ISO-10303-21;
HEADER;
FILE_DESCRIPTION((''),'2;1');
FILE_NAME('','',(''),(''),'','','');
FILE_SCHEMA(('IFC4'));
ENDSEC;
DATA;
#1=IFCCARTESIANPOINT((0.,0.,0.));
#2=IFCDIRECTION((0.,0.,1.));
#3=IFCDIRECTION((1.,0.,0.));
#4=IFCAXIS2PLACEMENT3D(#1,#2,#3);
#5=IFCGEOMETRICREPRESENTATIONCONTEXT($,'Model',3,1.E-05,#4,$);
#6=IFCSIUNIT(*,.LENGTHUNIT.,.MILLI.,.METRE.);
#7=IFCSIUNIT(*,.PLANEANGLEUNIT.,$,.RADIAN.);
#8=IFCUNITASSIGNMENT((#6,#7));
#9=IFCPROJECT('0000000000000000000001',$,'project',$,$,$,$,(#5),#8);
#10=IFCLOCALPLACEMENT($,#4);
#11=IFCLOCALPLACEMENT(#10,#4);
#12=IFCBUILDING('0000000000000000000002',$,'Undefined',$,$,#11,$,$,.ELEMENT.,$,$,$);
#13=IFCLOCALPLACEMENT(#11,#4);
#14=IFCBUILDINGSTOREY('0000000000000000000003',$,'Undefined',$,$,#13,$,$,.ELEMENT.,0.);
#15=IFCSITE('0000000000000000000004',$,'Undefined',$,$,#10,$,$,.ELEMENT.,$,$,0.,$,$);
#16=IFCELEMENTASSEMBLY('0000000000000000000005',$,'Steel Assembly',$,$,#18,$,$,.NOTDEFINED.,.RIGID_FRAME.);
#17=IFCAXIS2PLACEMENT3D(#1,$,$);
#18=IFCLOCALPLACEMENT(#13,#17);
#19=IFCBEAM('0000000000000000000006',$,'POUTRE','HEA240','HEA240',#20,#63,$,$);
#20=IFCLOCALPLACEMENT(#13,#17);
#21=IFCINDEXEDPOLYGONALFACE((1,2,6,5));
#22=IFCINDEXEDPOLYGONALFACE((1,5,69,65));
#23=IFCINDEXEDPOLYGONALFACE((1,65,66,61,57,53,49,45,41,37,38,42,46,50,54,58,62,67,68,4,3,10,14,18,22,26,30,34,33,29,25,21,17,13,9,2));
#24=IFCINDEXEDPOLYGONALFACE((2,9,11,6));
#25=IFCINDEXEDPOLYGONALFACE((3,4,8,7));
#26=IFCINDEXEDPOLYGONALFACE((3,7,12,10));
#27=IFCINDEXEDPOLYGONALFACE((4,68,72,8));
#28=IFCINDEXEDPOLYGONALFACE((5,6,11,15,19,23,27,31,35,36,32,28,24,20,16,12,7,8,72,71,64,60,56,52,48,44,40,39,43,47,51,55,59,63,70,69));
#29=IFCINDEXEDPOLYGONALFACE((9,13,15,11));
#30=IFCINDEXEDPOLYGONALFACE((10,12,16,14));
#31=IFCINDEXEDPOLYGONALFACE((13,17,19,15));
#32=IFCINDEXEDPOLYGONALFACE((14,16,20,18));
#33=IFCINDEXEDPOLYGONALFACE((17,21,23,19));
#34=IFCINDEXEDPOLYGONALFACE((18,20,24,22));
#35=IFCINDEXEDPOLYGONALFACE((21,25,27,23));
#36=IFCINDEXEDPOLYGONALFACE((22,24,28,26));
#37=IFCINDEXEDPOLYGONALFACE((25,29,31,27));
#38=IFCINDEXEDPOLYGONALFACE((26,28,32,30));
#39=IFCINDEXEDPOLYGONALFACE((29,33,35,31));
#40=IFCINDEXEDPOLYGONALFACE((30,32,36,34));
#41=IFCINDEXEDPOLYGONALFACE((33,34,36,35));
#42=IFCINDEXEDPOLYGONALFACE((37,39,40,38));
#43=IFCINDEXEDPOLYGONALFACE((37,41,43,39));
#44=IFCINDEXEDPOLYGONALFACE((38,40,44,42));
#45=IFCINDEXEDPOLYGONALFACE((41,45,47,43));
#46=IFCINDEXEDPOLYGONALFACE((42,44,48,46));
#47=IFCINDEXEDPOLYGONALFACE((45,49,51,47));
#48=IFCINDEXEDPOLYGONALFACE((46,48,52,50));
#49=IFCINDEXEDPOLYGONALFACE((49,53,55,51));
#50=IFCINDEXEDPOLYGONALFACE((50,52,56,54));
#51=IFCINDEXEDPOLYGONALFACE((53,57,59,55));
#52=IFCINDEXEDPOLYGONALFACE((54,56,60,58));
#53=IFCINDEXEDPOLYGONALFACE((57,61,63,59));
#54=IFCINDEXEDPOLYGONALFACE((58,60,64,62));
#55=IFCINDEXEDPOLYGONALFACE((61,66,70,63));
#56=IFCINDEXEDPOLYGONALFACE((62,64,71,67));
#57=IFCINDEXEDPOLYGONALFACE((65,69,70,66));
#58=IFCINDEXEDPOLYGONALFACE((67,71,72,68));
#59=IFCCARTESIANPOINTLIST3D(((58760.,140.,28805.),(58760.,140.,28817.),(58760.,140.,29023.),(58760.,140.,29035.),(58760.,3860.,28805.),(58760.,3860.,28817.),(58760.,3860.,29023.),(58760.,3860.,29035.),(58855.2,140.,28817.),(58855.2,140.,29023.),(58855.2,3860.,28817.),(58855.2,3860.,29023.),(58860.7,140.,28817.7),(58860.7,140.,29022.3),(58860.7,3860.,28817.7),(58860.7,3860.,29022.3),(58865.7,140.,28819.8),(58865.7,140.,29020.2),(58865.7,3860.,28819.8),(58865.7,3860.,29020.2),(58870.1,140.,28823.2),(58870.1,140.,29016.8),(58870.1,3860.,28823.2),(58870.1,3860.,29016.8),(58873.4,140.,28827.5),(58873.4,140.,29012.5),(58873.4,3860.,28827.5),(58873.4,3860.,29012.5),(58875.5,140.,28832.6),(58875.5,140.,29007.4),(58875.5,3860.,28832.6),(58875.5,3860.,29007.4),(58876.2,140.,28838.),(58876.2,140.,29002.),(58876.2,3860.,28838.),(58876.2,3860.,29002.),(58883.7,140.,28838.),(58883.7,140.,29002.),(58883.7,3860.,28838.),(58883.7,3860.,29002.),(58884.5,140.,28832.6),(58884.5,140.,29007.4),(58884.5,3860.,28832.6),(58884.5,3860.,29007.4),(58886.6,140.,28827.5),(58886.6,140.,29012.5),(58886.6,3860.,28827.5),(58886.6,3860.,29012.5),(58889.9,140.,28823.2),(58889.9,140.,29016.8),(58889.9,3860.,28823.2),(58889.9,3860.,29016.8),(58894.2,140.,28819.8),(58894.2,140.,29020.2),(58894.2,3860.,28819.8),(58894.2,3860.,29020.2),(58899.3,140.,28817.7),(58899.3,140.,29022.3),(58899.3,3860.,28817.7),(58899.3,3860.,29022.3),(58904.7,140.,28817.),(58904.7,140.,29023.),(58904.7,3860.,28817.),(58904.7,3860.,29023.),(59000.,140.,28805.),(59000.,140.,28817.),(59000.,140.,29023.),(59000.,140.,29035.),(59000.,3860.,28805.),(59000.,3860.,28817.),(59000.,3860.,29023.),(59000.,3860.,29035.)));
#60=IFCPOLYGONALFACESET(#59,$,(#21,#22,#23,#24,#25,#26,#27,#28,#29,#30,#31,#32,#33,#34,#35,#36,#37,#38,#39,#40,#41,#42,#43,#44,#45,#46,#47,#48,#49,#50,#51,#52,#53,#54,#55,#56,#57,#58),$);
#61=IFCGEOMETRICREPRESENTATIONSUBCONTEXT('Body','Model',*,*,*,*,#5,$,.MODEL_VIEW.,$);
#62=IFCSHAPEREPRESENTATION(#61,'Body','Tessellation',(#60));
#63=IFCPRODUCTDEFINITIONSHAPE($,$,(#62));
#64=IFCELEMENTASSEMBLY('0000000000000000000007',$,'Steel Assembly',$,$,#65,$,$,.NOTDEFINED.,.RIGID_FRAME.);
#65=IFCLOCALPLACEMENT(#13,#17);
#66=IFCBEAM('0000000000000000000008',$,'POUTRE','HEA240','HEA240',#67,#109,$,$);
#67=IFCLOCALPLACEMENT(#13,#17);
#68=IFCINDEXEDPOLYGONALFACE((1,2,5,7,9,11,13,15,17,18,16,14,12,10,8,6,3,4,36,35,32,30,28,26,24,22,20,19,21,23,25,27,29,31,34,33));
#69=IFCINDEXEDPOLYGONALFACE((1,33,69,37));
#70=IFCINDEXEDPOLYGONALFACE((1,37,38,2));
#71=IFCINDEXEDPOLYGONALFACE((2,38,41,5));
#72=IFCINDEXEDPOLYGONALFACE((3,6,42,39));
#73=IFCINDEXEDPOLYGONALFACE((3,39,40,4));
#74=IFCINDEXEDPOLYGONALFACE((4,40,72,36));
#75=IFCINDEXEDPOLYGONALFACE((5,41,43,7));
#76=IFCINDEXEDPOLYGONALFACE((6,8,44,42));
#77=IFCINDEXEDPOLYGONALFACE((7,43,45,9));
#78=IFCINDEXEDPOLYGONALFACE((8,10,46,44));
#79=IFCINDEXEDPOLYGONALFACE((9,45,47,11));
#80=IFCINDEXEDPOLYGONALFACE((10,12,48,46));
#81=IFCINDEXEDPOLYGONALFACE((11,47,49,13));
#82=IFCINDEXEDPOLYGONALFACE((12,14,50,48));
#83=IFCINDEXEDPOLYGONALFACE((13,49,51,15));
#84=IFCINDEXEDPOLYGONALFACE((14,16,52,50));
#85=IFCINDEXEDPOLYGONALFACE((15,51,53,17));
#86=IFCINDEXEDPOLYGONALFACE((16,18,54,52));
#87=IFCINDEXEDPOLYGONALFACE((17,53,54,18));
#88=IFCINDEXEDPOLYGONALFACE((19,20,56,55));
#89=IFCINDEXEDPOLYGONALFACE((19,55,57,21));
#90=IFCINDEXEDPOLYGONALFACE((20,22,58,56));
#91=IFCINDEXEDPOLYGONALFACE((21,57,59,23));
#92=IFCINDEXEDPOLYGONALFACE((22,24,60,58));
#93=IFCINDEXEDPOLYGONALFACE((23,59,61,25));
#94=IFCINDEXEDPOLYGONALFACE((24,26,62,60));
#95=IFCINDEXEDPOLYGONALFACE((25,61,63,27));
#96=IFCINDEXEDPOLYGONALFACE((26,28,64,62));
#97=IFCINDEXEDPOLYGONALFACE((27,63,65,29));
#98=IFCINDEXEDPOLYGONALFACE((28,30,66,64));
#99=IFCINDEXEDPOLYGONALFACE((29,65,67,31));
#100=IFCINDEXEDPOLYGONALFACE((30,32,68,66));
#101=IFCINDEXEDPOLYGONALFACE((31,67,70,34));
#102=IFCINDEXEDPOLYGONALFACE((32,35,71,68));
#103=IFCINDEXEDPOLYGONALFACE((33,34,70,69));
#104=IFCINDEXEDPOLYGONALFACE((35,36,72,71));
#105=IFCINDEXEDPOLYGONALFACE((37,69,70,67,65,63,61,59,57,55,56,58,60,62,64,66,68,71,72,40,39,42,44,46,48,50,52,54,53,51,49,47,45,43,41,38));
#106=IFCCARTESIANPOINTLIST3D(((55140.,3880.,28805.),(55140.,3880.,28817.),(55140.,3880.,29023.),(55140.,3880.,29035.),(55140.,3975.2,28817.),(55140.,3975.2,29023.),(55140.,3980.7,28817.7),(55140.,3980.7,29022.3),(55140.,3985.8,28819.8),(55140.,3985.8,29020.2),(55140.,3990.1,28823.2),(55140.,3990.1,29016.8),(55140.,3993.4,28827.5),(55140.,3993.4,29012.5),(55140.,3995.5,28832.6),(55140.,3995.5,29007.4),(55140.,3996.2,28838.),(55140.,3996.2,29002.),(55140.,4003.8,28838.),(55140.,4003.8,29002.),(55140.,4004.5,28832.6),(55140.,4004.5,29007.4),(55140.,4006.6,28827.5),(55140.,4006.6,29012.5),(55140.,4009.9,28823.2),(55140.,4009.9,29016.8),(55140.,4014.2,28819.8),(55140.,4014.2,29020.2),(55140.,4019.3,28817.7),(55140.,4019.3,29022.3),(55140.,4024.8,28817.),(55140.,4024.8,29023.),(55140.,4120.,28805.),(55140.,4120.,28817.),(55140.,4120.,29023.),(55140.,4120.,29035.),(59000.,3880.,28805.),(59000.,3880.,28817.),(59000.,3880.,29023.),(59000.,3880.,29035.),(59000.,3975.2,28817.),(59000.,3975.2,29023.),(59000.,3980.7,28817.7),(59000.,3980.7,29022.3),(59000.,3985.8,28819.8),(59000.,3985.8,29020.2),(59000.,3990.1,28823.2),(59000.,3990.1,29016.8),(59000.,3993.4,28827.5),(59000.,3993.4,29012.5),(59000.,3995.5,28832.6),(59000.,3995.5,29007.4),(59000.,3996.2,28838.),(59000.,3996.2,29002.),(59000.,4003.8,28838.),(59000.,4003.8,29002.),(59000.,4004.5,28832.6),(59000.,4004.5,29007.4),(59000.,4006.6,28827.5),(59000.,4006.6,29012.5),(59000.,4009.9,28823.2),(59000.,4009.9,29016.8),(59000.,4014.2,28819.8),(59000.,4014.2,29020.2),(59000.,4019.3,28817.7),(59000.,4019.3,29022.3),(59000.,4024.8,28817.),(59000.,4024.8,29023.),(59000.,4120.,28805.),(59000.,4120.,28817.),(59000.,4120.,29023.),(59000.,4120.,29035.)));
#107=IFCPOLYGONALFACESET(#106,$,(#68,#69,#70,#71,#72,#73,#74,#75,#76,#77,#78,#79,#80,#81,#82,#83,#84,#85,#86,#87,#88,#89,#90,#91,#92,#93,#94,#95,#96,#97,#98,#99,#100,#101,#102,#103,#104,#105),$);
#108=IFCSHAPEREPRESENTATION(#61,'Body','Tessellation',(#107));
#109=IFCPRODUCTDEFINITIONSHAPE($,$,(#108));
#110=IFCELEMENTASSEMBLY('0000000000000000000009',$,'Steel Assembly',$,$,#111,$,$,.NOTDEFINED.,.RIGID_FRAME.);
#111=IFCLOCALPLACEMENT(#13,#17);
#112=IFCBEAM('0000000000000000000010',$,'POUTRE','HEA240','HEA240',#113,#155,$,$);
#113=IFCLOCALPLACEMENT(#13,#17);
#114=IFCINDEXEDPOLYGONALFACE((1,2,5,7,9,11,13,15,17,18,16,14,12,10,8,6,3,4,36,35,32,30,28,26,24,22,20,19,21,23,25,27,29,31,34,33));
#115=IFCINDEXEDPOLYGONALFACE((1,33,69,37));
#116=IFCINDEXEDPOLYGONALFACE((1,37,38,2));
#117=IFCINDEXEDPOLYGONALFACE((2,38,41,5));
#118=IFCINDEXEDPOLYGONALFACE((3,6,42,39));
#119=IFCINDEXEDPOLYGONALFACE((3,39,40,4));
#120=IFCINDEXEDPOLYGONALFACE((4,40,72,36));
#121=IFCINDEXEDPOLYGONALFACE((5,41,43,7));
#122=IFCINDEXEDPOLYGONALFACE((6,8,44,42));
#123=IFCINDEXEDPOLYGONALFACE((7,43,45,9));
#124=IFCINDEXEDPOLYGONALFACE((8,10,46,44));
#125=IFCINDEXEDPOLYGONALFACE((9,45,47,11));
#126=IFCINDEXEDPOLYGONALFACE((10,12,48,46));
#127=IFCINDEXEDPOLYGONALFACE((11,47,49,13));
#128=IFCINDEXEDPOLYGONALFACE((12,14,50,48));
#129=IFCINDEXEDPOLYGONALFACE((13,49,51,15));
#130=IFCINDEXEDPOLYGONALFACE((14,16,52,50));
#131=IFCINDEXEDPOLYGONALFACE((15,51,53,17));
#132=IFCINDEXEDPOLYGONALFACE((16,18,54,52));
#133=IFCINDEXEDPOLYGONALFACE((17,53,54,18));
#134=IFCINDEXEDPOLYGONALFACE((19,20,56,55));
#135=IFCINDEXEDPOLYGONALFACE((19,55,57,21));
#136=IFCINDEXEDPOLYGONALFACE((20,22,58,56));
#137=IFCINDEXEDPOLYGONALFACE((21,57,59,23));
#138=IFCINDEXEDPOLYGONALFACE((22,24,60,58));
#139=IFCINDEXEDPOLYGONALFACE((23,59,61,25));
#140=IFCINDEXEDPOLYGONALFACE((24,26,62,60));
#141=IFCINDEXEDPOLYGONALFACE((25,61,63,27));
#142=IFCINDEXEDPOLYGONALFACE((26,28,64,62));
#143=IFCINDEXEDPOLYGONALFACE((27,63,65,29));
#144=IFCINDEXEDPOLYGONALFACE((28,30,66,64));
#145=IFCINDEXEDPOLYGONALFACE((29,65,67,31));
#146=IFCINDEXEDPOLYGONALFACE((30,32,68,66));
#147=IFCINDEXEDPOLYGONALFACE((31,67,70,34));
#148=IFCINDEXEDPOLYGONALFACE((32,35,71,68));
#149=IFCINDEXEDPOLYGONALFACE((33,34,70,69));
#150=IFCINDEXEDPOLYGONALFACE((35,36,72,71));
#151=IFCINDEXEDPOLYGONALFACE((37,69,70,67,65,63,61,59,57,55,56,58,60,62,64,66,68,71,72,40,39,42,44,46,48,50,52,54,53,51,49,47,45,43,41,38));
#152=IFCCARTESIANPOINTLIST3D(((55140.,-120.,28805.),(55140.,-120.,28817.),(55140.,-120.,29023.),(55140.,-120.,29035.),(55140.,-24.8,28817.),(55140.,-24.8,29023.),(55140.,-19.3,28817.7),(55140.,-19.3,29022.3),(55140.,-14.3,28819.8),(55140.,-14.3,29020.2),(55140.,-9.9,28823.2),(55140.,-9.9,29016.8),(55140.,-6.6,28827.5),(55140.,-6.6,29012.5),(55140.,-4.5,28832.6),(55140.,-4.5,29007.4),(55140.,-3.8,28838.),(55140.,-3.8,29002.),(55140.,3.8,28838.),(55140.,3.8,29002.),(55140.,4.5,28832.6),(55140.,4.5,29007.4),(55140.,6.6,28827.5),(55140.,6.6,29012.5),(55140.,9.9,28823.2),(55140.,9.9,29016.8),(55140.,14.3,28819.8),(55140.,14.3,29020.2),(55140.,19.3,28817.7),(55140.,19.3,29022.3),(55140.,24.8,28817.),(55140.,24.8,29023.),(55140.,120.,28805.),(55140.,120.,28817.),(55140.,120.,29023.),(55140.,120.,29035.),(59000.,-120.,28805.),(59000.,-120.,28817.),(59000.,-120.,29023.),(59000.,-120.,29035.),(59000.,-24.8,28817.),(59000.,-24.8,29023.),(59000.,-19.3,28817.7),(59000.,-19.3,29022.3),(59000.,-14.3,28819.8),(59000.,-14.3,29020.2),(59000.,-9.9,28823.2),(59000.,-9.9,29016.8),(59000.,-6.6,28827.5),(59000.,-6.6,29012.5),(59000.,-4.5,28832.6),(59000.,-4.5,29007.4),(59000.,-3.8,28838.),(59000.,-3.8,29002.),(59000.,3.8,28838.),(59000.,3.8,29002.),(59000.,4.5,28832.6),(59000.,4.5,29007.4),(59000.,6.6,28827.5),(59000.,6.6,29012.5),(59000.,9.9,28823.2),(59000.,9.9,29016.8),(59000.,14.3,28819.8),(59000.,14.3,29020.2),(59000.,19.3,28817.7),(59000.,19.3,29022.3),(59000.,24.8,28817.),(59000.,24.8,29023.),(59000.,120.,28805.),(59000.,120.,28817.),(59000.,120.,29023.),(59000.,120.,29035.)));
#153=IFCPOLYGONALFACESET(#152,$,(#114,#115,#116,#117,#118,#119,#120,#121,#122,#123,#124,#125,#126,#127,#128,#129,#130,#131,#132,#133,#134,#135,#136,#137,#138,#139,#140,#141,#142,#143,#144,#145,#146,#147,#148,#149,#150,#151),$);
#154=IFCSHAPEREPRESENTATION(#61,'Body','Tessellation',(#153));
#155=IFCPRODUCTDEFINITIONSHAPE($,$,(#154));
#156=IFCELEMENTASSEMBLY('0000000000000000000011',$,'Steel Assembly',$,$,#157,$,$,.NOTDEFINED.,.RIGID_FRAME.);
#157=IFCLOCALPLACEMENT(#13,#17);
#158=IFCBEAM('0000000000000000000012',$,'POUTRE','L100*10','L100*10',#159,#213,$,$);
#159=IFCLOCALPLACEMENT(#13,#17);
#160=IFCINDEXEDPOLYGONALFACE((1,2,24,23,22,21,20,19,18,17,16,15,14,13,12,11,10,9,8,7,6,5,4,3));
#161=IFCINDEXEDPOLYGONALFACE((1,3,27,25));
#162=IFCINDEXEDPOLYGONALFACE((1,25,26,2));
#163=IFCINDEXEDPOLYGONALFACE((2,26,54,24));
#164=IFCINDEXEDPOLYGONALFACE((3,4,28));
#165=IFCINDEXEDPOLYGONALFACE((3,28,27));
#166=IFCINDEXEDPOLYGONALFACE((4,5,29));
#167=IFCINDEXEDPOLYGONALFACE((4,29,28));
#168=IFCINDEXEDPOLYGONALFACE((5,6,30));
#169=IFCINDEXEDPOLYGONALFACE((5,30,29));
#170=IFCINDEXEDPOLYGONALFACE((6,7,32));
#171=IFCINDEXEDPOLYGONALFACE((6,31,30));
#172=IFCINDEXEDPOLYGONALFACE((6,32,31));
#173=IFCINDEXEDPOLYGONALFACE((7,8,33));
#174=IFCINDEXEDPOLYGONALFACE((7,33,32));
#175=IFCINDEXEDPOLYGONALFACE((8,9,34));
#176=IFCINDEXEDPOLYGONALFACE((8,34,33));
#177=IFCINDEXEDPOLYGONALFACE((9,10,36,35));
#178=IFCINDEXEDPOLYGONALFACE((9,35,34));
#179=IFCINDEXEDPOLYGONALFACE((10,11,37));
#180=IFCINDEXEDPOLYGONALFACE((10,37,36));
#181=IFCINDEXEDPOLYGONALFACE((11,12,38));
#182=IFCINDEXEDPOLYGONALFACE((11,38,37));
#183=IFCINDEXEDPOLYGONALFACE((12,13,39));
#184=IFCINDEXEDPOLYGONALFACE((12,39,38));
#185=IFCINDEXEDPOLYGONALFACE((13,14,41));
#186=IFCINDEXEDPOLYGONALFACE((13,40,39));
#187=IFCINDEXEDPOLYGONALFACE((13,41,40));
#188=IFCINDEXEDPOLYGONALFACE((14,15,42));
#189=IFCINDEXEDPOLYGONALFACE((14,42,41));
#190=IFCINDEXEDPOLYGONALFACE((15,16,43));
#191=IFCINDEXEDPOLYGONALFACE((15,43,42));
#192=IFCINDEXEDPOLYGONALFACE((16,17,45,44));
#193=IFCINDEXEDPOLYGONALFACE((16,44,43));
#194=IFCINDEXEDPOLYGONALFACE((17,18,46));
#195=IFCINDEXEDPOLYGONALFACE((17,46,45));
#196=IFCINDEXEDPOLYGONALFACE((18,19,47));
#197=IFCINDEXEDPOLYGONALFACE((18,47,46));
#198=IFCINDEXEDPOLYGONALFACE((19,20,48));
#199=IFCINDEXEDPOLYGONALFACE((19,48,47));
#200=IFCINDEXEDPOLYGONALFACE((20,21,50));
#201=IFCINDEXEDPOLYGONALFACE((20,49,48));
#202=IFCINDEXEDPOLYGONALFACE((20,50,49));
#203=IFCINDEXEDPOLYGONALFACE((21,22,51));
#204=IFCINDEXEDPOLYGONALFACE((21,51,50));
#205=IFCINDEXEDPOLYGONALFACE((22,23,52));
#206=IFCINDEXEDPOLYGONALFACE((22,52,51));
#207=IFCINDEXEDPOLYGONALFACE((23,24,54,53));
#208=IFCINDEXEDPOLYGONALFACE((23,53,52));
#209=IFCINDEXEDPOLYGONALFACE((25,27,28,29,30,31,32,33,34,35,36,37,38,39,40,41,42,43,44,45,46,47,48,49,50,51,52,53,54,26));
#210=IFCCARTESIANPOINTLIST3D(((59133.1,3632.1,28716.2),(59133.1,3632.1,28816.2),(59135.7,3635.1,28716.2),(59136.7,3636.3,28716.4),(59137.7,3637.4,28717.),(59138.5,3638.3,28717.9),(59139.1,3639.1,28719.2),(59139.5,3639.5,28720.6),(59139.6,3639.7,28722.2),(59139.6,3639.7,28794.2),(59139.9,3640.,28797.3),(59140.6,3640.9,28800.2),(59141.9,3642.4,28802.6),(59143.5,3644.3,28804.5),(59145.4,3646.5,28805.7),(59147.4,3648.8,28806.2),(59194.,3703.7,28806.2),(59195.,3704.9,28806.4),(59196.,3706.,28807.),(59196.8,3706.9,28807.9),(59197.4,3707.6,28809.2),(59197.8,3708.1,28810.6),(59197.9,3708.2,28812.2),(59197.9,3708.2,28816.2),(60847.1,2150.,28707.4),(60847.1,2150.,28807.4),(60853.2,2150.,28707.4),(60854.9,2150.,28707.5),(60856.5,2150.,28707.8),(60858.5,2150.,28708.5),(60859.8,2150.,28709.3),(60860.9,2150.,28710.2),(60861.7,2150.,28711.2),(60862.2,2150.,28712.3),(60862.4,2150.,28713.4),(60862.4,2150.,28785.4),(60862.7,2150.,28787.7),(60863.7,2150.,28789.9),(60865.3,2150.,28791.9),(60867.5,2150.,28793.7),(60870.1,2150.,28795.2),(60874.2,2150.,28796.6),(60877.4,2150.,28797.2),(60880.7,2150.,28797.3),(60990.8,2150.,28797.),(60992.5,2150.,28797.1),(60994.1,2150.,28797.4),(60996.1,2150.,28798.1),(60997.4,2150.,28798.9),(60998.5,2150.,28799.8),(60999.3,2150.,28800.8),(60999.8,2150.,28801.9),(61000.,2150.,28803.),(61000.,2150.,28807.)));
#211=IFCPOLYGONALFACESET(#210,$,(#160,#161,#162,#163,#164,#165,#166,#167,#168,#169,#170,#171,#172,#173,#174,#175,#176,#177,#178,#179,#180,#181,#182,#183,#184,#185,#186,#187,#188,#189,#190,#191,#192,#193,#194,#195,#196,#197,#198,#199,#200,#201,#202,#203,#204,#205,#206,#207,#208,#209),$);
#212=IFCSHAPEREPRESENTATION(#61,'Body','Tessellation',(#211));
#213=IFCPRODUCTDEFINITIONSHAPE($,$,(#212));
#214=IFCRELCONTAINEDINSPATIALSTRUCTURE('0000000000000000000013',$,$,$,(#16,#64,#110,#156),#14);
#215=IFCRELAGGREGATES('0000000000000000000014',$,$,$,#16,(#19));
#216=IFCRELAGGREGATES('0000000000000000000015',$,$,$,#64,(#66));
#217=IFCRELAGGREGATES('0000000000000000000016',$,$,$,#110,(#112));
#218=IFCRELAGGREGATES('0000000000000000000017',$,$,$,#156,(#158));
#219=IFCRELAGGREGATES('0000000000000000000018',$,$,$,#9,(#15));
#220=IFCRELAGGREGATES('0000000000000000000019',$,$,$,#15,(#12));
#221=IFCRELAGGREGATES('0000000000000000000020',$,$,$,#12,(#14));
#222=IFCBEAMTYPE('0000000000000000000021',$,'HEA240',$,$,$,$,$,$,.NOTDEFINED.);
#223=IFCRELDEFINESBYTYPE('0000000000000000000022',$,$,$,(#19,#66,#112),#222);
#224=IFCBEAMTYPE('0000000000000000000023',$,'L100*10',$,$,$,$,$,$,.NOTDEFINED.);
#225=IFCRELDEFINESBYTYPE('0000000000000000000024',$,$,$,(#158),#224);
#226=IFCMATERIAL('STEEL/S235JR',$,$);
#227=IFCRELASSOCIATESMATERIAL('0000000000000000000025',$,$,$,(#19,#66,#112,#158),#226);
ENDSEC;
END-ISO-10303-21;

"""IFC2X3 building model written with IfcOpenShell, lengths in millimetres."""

from ifc_helpers import new_model, si_unit, frame, origin_with_axes, origin_2d_with_axis, place, context, subcontext, project, spatial, i_section, l_section, extrude, clip, halfspace, material, type_object, element, aggregate, save


model = new_model("IFC2X3")

# Units and contexts
model_context = context("Model", 3, precision=1e-05, world=origin_with_axes())
body_context = subcontext(model_context, "Body", "Model", "MODEL_VIEW")
ifc_project = project(units=[si_unit("LENGTHUNIT", "METRE", prefix="MILLI"), si_unit("PLANEANGLEUNIT", "RADIAN")], contexts=[model_context])

# Site, building, storey
site_placement = place(None, origin_with_axes())
site = spatial("IfcSite", under=ifc_project, at=site_placement, Name="Undefined", CompositionType="ELEMENT", RefElevation=0.0)
building_placement = place(site_placement, origin_with_axes())
building = spatial("IfcBuilding", under=site, at=building_placement, Name="Undefined", CompositionType="ELEMENT")
storey_placement = place(building_placement, origin_with_axes())
storey = spatial("IfcBuildingStorey", under=building, at=storey_placement, Name="Undefined", CompositionType="ELEMENT", Elevation=0.0)

# Element assemblies, beams
assembly_1_placement = place(storey_placement, origin_with_axes())
assembly_1 = element("IfcElementAssembly", 1, at=assembly_1_placement, inside=storey, Name="Steel Assembly", AssemblyPlace="NOTDEFINED", PredefinedType="RIGID_FRAME")
ifc_material_1 = material(Name="STEEL/S235JR")
beam_type_1 = type_object("IfcBeamType", Name="HEA240", PredefinedType="NOTDEFINED")
beam_1_placement = place(assembly_1_placement, frame((58880.0, 120.0, 28920.0), z_axis=(0.0, 0.0, 1.0), x_axis=(0.0, 1.0, 0.0)))
beam_1 = element("IfcBeam", 2, at=beam_1_placement, type_object=beam_type_1, material=ifc_material_1, Name="POUTRE", Description="HEA240", ObjectType="HEA240", context=body_context, shape_type="SweptSolid", body=[
    extrude(i_section(OverallWidth=240.0, OverallDepth=230.0, WebThickness=7.5, FlangeThickness=12.0, FilletRadius=21.0, at=origin_2d_with_axis()), frame((3740.0, 0.0, 0.0), z_axis=(-1.0, 0.0, 0.0), x_axis=(0.0, -1.0, 0.0)), (0.0, 0.0, 1.0), 3720.0),
])
assembly_2_placement = place(storey_placement, origin_with_axes())
assembly_2 = element("IfcElementAssembly", 3, at=assembly_2_placement, inside=storey, Name="Steel Assembly", AssemblyPlace="NOTDEFINED", PredefinedType="RIGID_FRAME")
beam_2_placement = place(assembly_2_placement, frame((59000.0, 4000.0, 28920.0), z_axis=(0.0, 0.0, 1.0), x_axis=(-1.0, 0.0, 0.0)))
beam_2 = element("IfcBeam", 4, at=beam_2_placement, type_object=beam_type_1, material=ifc_material_1, Name="POUTRE", Description="HEA240", ObjectType="HEA240", context=body_context, shape_type="SweptSolid", body=[
    extrude(i_section(OverallWidth=240.0, OverallDepth=230.0, WebThickness=7.5, FlangeThickness=12.0, FilletRadius=21.0, at=origin_2d_with_axis()), frame((3860.0, 0.0, 0.0), z_axis=(-1.0, 0.0, 0.0), x_axis=(0.0, -1.0, 0.0)), (0.0, 0.0, 1.0), 3860.0),
])
assembly_3_placement = place(storey_placement, origin_with_axes())
assembly_3 = element("IfcElementAssembly", 5, at=assembly_3_placement, inside=storey, Name="Steel Assembly", AssemblyPlace="NOTDEFINED", PredefinedType="RIGID_FRAME")
beam_3_placement = place(assembly_3_placement, frame((59000.0, 0.0, 28920.0), z_axis=(0.0, 0.0, 1.0), x_axis=(-1.0, 0.0, 0.0)))
beam_3 = element("IfcBeam", 6, at=beam_3_placement, type_object=beam_type_1, material=ifc_material_1, Name="POUTRE", Description="HEA240", ObjectType="HEA240", context=body_context, shape_type="SweptSolid", body=[
    extrude(i_section(OverallWidth=240.0, OverallDepth=230.0, WebThickness=7.5, FlangeThickness=12.0, FilletRadius=21.0, at=origin_2d_with_axis()), frame((3860.0, 0.0, 0.0), z_axis=(-1.0, 0.0, 0.0), x_axis=(0.0, -1.0, 0.0)), (0.0, 0.0, 1.0), 3860.0),
])
beam_type_2 = type_object("IfcBeamType", Name="L100*10", PredefinedType="NOTDEFINED")
assembly_4_placement = place(storey_placement, origin_with_axes())
assembly_4 = element("IfcElementAssembly", 7, at=assembly_4_placement, inside=storey, Name="Steel Assembly", AssemblyPlace="NOTDEFINED", PredefinedType="RIGID_FRAME")
beam_4_placement = place(assembly_4_placement, frame((60966.7, 2112.7, 28757.0), z_axis=(0.654079, 0.756427, 0.0), x_axis=(-0.756421, 0.654074, 0.003846)))
beam_4 = element("IfcBeam", 8, at=beam_4_placement, type_object=beam_type_2, material=ifc_material_1, Name="POUTRE", Description="L100*10", ObjectType="L100*10", context=body_context, shape_type="Clipping", body=[
    clip(clip(extrude(l_section(Depth=100.0, Width=100.0, Thickness=10.0, FilletRadius=12.0, EdgeRadius=6.0, at=origin_2d_with_axis()), frame((2489.9, 0.0, 0.0), z_axis=(-1.0, 0.0, 0.0), x_axis=(0.0, -1.0, 0.0)), (0.0, 0.0, 1.0), 2541.2), halfspace(frame((2382.2, 168.3, 51.8), z_axis=(-0.999958, 0.003846, 0.008304), x_axis=(-0.008304, 0.000032, -0.999966)), True)), halfspace(frame((91.4, 165.1, -29.2), z_axis=(0.654074, -0.002516, 0.756427), x_axis=(-0.756421, 0.002909, 0.654079)), True)),
])

aggregate(assembly_1, [beam_1])
aggregate(assembly_2, [beam_2])
aggregate(assembly_3, [beam_3])

aggregate(assembly_4, [beam_4])

save(model, "model.ifc")
